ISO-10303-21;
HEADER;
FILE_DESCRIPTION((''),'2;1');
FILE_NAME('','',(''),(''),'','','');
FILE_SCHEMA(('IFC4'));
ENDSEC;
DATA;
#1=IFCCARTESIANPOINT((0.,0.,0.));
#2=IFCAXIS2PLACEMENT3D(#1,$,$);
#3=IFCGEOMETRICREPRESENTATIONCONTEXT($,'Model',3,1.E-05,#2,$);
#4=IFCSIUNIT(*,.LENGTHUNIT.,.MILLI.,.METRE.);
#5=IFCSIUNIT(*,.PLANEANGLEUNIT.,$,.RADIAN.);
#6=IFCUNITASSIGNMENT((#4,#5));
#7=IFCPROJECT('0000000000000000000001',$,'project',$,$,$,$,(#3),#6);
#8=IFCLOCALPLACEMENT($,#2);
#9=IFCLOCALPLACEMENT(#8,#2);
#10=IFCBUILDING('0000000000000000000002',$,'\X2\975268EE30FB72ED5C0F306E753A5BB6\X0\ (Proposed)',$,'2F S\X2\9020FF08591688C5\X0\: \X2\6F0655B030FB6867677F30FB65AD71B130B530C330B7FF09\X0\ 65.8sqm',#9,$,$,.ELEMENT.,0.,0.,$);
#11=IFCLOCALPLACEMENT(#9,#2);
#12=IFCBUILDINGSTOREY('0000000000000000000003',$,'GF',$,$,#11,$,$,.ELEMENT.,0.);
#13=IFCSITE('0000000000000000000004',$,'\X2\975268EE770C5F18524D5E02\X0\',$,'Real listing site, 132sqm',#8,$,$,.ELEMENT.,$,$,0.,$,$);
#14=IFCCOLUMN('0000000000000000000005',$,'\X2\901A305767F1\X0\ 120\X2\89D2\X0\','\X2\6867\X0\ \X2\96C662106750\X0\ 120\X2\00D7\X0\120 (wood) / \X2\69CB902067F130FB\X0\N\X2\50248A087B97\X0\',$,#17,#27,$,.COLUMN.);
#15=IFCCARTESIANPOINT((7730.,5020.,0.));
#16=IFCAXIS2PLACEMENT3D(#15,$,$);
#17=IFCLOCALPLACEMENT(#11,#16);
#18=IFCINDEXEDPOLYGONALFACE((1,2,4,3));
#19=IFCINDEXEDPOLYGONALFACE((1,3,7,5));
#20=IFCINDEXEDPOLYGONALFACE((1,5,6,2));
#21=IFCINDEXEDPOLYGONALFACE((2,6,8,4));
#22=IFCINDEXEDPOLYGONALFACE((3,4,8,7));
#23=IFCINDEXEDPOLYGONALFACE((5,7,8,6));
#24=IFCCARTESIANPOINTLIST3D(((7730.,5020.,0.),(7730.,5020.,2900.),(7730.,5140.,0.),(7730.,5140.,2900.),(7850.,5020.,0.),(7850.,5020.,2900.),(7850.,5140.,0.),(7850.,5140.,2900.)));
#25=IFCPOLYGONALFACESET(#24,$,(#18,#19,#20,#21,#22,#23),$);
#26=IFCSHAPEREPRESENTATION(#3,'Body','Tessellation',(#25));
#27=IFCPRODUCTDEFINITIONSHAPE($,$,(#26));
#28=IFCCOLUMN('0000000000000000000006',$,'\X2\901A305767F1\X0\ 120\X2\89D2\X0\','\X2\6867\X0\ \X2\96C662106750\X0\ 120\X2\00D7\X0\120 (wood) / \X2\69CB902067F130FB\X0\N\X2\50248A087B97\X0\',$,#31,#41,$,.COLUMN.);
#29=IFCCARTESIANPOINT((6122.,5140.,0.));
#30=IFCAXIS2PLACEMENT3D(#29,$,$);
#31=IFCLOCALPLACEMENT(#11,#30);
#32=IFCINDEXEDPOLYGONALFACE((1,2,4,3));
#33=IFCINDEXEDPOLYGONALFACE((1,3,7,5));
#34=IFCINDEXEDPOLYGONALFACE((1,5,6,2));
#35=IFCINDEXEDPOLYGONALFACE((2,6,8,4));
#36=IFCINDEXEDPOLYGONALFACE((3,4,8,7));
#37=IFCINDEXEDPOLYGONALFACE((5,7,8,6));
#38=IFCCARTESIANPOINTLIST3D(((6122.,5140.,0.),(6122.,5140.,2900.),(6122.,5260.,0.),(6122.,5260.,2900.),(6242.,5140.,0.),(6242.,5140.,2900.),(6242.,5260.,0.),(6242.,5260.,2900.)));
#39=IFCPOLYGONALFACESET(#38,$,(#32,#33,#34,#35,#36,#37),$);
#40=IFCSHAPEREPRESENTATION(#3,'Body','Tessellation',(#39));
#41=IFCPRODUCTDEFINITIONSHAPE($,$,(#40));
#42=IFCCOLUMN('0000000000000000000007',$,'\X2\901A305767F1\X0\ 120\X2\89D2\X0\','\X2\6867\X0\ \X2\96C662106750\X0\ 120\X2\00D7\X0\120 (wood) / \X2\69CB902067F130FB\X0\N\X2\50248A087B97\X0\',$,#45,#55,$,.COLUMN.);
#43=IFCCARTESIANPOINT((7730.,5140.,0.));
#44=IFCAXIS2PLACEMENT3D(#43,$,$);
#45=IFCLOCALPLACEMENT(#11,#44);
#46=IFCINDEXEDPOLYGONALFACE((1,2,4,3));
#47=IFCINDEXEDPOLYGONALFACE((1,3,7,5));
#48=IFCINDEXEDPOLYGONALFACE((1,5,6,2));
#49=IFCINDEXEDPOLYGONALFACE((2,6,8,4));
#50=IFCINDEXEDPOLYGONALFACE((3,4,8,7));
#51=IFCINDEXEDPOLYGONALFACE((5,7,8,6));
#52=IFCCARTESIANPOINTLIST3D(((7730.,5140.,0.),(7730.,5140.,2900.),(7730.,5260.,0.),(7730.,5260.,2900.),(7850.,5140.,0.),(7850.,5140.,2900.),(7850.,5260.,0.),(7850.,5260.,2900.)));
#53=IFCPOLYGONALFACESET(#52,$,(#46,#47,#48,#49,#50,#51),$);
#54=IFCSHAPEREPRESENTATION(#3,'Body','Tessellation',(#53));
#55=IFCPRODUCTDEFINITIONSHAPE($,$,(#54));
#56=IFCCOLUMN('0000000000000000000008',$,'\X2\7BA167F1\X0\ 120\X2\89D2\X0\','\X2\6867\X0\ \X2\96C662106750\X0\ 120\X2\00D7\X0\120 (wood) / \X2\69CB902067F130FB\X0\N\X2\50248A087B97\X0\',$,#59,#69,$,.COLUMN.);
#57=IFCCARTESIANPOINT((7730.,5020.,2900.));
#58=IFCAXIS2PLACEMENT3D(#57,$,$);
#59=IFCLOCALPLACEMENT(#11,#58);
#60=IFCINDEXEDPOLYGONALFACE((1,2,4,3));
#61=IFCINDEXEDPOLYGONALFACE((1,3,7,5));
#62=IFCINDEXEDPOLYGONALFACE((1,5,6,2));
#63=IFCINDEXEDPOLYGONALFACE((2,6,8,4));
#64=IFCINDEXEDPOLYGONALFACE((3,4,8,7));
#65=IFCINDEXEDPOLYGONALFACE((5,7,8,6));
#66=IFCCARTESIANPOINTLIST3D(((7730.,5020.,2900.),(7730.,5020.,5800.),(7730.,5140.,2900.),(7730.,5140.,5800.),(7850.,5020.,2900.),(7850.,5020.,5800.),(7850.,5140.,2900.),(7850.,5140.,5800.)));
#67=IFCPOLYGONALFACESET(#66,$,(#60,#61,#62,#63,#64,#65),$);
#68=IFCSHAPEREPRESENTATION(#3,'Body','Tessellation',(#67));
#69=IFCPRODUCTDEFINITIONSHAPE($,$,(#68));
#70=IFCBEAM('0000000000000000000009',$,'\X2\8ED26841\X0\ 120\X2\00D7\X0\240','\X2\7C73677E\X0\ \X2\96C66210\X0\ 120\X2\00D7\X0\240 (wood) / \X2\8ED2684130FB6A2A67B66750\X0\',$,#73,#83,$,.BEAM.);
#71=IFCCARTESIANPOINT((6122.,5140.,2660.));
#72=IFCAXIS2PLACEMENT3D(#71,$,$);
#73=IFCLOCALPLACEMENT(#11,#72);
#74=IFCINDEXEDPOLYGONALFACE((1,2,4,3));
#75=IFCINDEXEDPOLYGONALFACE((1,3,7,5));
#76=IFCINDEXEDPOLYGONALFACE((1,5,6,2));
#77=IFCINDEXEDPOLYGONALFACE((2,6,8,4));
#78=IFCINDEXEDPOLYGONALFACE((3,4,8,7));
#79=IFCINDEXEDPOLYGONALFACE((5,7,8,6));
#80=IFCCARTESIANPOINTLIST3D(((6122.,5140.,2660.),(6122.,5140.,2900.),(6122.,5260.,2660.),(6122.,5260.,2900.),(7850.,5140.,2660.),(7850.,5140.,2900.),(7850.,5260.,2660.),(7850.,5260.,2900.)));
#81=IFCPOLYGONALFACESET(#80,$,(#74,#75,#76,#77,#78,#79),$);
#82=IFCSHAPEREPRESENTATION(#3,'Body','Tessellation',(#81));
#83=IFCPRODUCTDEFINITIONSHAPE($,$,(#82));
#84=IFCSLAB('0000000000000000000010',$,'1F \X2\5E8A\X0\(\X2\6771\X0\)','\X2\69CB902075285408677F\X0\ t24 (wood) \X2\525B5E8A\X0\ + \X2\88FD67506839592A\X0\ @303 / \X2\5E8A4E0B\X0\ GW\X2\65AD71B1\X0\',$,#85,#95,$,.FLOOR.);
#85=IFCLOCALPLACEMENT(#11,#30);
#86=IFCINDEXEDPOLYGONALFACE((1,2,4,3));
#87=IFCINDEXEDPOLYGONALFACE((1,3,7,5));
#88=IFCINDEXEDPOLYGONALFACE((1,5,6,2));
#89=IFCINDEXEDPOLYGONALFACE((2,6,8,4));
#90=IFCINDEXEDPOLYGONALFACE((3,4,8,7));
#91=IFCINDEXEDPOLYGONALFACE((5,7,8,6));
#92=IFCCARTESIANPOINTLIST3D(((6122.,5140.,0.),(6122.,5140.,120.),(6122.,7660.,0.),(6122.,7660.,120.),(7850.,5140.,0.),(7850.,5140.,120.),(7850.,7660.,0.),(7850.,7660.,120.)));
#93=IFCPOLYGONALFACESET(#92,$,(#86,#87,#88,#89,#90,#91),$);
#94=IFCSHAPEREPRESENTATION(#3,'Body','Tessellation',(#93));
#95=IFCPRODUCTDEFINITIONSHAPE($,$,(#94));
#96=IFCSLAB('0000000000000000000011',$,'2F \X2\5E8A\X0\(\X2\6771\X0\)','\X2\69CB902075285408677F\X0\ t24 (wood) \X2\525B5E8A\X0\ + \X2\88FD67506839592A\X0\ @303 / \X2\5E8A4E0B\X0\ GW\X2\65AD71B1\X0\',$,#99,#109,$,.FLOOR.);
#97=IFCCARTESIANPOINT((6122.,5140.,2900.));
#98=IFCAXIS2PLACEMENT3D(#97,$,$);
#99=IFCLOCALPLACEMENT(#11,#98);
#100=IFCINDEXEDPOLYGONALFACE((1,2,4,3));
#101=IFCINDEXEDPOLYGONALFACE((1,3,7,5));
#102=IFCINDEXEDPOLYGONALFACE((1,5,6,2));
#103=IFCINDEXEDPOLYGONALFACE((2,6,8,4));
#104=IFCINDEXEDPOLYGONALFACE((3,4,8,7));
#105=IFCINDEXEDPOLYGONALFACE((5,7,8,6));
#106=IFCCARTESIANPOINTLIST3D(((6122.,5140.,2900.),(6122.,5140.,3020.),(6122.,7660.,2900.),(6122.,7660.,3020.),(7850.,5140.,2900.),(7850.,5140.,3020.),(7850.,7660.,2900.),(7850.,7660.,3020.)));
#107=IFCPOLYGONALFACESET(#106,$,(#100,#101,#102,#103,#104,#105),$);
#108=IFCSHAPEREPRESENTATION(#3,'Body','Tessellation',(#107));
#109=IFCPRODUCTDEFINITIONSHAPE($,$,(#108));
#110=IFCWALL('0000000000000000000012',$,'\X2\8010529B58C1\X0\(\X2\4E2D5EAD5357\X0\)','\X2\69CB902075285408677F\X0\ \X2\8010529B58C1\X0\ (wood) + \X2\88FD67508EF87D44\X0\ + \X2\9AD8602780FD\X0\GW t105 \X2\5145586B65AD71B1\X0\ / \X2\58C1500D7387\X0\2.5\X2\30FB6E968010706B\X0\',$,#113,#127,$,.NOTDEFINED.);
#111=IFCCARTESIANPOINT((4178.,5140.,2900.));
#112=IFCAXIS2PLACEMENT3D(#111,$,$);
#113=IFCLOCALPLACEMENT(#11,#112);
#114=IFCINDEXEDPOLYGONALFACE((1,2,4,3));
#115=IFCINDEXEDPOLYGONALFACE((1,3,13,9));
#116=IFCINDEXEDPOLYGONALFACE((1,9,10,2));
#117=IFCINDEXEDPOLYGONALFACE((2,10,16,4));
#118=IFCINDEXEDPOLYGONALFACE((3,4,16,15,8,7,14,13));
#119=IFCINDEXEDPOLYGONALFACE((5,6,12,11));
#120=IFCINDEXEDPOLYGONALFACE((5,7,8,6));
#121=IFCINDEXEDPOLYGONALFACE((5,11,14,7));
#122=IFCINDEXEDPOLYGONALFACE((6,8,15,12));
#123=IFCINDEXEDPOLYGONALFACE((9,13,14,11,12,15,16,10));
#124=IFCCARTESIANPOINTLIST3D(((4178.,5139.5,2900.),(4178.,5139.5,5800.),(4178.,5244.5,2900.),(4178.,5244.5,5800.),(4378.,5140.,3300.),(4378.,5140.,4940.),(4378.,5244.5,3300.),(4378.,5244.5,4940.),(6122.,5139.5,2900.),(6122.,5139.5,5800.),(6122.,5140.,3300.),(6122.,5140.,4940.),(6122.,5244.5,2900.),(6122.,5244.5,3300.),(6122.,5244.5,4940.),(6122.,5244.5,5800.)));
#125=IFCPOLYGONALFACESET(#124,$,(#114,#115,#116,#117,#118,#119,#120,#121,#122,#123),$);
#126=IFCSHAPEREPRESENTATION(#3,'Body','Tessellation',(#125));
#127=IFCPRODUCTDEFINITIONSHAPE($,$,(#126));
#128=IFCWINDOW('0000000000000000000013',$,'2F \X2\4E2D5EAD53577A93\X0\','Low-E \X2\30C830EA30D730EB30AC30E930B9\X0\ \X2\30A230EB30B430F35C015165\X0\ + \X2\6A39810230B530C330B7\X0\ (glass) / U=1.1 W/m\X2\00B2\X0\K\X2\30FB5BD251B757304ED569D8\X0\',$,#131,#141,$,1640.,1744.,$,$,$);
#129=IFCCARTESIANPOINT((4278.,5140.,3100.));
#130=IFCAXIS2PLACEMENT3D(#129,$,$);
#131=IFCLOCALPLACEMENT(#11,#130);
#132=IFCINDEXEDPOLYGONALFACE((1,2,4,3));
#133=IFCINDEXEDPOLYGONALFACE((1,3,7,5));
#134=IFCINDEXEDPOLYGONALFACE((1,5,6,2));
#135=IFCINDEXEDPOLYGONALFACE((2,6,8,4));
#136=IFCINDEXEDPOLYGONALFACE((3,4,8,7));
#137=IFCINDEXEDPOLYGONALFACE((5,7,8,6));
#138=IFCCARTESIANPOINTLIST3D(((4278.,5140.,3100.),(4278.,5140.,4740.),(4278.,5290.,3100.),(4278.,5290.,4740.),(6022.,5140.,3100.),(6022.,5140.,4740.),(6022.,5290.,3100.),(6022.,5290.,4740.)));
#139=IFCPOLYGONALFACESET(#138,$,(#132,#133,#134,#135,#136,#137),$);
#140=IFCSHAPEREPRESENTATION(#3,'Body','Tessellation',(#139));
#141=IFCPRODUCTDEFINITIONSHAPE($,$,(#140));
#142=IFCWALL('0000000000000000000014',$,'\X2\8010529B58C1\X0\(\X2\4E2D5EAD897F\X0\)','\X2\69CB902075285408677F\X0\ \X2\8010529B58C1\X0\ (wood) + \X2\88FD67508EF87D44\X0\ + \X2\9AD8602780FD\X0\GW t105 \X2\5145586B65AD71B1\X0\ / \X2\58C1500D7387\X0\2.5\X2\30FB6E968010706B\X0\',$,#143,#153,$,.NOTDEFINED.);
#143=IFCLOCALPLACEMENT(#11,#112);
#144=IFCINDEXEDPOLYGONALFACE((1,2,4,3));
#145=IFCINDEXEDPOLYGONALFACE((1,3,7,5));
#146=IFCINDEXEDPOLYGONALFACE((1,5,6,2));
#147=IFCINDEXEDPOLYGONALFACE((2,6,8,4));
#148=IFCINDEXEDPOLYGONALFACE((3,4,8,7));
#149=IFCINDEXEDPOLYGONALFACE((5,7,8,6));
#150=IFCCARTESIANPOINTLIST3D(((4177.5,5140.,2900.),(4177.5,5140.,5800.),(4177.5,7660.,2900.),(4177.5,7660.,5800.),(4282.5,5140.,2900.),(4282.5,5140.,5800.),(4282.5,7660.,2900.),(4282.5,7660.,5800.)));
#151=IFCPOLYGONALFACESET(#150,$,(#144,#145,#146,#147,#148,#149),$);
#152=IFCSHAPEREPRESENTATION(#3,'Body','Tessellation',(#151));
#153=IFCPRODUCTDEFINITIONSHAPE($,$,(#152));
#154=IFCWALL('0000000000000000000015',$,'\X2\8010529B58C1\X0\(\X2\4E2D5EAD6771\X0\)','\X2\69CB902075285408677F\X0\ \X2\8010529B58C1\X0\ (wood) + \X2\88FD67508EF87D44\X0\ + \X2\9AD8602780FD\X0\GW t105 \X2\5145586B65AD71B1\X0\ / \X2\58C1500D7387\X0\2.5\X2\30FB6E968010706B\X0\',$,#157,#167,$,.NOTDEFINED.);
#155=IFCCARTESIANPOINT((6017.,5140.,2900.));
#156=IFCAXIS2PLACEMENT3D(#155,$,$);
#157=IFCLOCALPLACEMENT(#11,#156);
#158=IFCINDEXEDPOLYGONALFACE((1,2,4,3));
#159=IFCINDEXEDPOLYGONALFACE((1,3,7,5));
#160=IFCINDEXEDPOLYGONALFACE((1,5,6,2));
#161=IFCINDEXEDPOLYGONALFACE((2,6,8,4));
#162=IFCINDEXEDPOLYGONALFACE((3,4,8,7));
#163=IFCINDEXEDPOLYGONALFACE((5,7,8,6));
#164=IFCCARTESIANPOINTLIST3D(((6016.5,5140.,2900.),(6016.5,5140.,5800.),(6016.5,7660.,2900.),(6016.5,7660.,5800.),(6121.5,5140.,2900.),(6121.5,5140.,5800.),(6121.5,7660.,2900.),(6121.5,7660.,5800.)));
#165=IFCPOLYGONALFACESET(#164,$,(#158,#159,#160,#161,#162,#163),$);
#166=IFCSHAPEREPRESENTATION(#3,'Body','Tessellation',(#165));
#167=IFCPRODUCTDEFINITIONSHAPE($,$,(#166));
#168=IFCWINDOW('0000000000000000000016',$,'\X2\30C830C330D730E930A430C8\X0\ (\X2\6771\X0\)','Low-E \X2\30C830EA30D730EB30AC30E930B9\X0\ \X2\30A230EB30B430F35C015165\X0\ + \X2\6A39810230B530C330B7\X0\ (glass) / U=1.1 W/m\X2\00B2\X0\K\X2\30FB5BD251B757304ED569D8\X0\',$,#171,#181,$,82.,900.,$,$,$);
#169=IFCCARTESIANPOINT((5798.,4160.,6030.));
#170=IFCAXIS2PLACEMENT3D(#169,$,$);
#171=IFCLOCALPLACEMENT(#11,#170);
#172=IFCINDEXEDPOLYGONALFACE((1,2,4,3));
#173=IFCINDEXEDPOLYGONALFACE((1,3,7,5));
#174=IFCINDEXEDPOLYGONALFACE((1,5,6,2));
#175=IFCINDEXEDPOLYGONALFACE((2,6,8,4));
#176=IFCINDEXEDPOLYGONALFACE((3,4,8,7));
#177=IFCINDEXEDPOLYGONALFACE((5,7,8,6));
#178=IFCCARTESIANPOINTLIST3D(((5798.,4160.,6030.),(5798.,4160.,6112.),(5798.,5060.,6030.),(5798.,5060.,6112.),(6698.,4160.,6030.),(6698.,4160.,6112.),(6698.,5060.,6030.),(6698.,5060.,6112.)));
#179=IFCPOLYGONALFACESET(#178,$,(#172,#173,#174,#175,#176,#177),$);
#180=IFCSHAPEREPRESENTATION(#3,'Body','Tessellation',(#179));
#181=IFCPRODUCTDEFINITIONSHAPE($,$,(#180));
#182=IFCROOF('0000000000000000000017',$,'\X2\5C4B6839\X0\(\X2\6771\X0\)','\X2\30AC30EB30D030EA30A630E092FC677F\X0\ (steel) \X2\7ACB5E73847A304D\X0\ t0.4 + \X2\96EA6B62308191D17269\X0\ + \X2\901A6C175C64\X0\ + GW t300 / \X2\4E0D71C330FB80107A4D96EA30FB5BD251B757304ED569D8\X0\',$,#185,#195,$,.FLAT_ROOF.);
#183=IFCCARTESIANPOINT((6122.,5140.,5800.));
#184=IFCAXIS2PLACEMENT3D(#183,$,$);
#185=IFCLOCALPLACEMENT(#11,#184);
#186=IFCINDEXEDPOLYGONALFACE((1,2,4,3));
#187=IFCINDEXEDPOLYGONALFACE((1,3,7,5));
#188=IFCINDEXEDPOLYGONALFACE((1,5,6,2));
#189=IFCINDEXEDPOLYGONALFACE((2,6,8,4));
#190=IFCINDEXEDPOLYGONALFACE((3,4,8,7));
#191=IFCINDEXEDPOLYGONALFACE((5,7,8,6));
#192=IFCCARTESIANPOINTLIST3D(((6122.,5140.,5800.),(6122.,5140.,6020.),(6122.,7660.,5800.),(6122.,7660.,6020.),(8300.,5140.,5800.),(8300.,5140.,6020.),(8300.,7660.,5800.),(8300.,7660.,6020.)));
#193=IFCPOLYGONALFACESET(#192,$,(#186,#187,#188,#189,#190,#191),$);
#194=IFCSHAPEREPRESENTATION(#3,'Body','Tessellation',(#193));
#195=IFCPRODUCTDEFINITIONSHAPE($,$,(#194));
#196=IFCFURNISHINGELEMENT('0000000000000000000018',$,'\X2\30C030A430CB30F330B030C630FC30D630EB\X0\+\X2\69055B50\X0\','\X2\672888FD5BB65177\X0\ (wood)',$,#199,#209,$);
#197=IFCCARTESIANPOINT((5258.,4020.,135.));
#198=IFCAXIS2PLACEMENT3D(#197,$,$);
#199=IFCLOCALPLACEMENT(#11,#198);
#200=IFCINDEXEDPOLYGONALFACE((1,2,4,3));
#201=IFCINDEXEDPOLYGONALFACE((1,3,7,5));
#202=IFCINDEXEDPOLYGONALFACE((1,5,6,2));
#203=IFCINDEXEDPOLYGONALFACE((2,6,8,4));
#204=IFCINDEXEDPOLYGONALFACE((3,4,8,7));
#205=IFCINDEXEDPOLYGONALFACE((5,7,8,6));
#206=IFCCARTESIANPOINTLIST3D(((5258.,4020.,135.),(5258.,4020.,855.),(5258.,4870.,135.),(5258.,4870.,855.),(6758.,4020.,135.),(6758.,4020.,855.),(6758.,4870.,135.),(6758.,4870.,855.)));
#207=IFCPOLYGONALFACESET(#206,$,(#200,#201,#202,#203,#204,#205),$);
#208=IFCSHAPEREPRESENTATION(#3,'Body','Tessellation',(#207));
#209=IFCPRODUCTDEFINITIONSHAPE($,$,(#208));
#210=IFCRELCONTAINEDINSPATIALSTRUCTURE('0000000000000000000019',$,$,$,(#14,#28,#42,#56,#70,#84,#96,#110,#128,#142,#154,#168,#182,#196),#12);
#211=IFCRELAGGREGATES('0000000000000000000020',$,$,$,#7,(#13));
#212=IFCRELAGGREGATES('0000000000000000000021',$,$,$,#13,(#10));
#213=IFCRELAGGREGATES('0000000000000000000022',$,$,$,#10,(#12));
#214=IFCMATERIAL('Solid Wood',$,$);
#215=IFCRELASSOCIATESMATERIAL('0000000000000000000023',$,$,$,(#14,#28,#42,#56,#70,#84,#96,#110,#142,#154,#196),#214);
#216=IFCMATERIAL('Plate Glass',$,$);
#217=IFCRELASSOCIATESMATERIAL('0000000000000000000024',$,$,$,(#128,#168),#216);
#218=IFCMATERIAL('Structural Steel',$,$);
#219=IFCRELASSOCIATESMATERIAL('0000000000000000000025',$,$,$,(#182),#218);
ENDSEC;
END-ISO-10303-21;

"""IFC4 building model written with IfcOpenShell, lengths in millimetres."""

from ifc_helpers import new_model, si_unit, frame, frame_2d, origin, place, context, project, spatial, rectangle, extrude, material, element, fill, save


model = new_model("IFC4")

# Units and contexts
model_context = context("Model", 3, precision=1e-05, world=origin())
ifc_project = project(units=[si_unit("LENGTHUNIT", "METRE", prefix="MILLI"), si_unit("PLANEANGLEUNIT", "RADIAN")], contexts=[model_context])

# Site, building, storey
site_placement = place(None, origin())
site = spatial("IfcSite", under=ifc_project, at=site_placement, Name="青森県弘前市", ObjectType="Real listing site, 132sqm", CompositionType="ELEMENT", RefElevation=0.0)
building_placement = place(site_placement, origin())
building = spatial("IfcBuilding", under=site, at=building_placement, Name="青森・狭小の町家 (Proposed)", ObjectType="2F S造（外装: 漆喰・桧板・断熱サッシ） 65.8sqm", CompositionType="ELEMENT", ElevationOfRefHeight=0.0, ElevationOfTerrain=0.0)
storey_placement = place(building_placement, origin())
storey = spatial("IfcBuildingStorey", under=building, at=storey_placement, Name="GF", CompositionType="ELEMENT", Elevation=0.0)

# Columns
ifc_material_1 = material(Name="Solid Wood")
column_1_placement = place(storey_placement, frame((7730.0, 5020.0, 0.0)))
element("IfcColumn", 1, at=column_1_placement, inside=storey, material=ifc_material_1, Name="通し柱 120角", Description="桧 集成材 120×120 (wood) / 構造柱・N値計算", PredefinedType="COLUMN", context=model_context, shape_type="SweptSolid", body=[
    extrude(rectangle(XDim=120.0, YDim=120.0, at=frame_2d((60.0, 60.0))), frame((7730.0, 5020.0, 0.0)), (0.0, 0.0, 1.0), 2900.0),
])
column_2_placement = place(storey_placement, frame((6122.0, 5140.0, 0.0)))
element("IfcColumn", 2, at=column_2_placement, inside=storey, material=ifc_material_1, Name="通し柱 120角", Description="桧 集成材 120×120 (wood) / 構造柱・N値計算", PredefinedType="COLUMN", context=model_context, shape_type="SweptSolid", body=[
    extrude(rectangle(XDim=120.0, YDim=120.0, at=frame_2d((60.0, 60.0))), frame((6122.0, 5140.0, 0.0)), (0.0, 0.0, 1.0), 2900.0),
])
column_3_placement = place(storey_placement, frame((7730.0, 5140.0, 0.0)))
element("IfcColumn", 3, at=column_3_placement, inside=storey, material=ifc_material_1, Name="通し柱 120角", Description="桧 集成材 120×120 (wood) / 構造柱・N値計算", PredefinedType="COLUMN", context=model_context, shape_type="SweptSolid", body=[
    extrude(rectangle(XDim=120.0, YDim=120.0, at=frame_2d((60.0, 60.0))), frame((7730.0, 5140.0, 0.0)), (0.0, 0.0, 1.0), 2900.0),
])
column_4_placement = place(storey_placement, frame((7730.0, 5020.0, 2900.0)))
element("IfcColumn", 4, at=column_4_placement, inside=storey, material=ifc_material_1, Name="管柱 120角", Description="桧 集成材 120×120 (wood) / 構造柱・N値計算", PredefinedType="COLUMN", context=model_context, shape_type="SweptSolid", body=[
    extrude(rectangle(XDim=120.0, YDim=120.0, at=frame_2d((60.0, 60.0))), frame((7730.0, 5020.0, 2900.0)), (0.0, 0.0, 1.0), 2900.0),
])

# Beam
beam_1_placement = place(storey_placement, frame((6122.0, 5140.0, 2660.0)))
element("IfcBeam", 5, at=beam_1_placement, inside=storey, material=ifc_material_1, Name="軒桁 120×240", Description="米松 集成 120×240 (wood) / 軒桁・横架材", PredefinedType="BEAM", context=model_context, shape_type="SweptSolid", body=[
    extrude(rectangle(XDim=1728.0, YDim=120.0, at=frame_2d((864.0, 60.0))), frame((6122.0, 5140.0, 2660.0)), (0.0, 0.0, 1.0), 240.0),
])

# Slabs
slab_1_placement = place(storey_placement, frame((6122.0, 5140.0, 0.0)))
element("IfcSlab", 6, at=slab_1_placement, inside=storey, material=ifc_material_1, Name="1F 床(東)", Description="構造用合板 t24 (wood) 剛床 + 製材根太 @303 / 床下 GW断熱", PredefinedType="FLOOR", context=model_context, shape_type="SweptSolid", body=[
    extrude(rectangle(XDim=1728.0, YDim=2520.0, at=frame_2d((864.0, 1260.0))), frame((6122.0, 5140.0, 0.0)), (0.0, 0.0, 1.0), 120.0),
])
slab_2_placement = place(storey_placement, frame((6122.0, 5140.0, 2900.0)))
element("IfcSlab", 7, at=slab_2_placement, inside=storey, material=ifc_material_1, Name="2F 床(東)", Description="構造用合板 t24 (wood) 剛床 + 製材根太 @303 / 床下 GW断熱", PredefinedType="FLOOR", context=model_context, shape_type="SweptSolid", body=[
    extrude(rectangle(XDim=1728.0, YDim=2520.0, at=frame_2d((864.0, 1260.0))), frame((6122.0, 5140.0, 2900.0)), (0.0, 0.0, 1.0), 120.0),
])

# Wall, opening, window
wall_1_placement = place(storey_placement, frame((4178.0, 5140.0, 2900.0)))
wall_1 = element("IfcWall", 8, at=wall_1_placement, inside=storey, material=ifc_material_1, Name="耐力壁(中庭南)", Description="構造用合板 耐力壁 (wood) + 製材軸組 + 高性能GW t105 充填断熱 / 壁倍率2.5・準耐火", PredefinedType="NOTDEFINED", context=model_context, shape_type="SweptSolid", body=[
    extrude(rectangle(XDim=1944.0, YDim=105.0, at=frame_2d((972.0, 52.0))), frame((4178.0, 5140.0, 2900.0)), (0.0, 0.0, 1.0), 2900.0),
])
opening_placement = place(storey_placement, frame((4278.0, 5140.0, 3100.0)))
opening = element("IfcOpeningElement", 9, at=opening_placement, cuts=wall_1, PredefinedType="NOTDEFINED", context=model_context, shape_type="SweptSolid", body=[
    extrude(rectangle(XDim=1744.0, YDim=150.0, at=frame_2d((872.0, 75.0))), frame((4278.0, 5140.0, 3100.0)), (0.0, 0.0, 1.0), 1640.0),
])
ifc_material_2 = material(Name="Plate Glass")
window_1_placement = place(storey_placement, frame((4278.0, 5140.0, 3100.0)))
window_1 = element("IfcWindow", 10, at=window_1_placement, inside=storey, material=ifc_material_2, Name="2F 中庭南窓", Description="Low-E トリプルガラス アルゴン封入 + 樹脂サッシ (glass) / U=1.1 W/m²K・寒冷地仕様", OverallHeight=1640.0, OverallWidth=1744.0, context=model_context, shape_type="SweptSolid", body=[
    extrude(rectangle(XDim=1744.0, YDim=150.0, at=frame_2d((872.0, 75.0))), frame((4278.0, 5140.0, 3100.0)), (0.0, 0.0, 1.0), 1640.0),
])
fill(opening, window_1)

# Walls
wall_2_placement = place(storey_placement, frame((4178.0, 5140.0, 2900.0)))
element("IfcWall", 11, at=wall_2_placement, inside=storey, material=ifc_material_1, Name="耐力壁(中庭西)", Description="構造用合板 耐力壁 (wood) + 製材軸組 + 高性能GW t105 充填断熱 / 壁倍率2.5・準耐火", PredefinedType="NOTDEFINED", context=model_context, shape_type="SweptSolid", body=[
    extrude(rectangle(XDim=105.0, YDim=2520.0, at=frame_2d((52.0, 1260.0))), frame((4178.0, 5140.0, 2900.0)), (0.0, 0.0, 1.0), 2900.0),
])
wall_3_placement = place(storey_placement, frame((6017.0, 5140.0, 2900.0)))
element("IfcWall", 12, at=wall_3_placement, inside=storey, material=ifc_material_1, Name="耐力壁(中庭東)", Description="構造用合板 耐力壁 (wood) + 製材軸組 + 高性能GW t105 充填断熱 / 壁倍率2.5・準耐火", PredefinedType="NOTDEFINED", context=model_context, shape_type="SweptSolid", body=[
    extrude(rectangle(XDim=105.0, YDim=2520.0, at=frame_2d((52.0, 1260.0))), frame((6017.0, 5140.0, 2900.0)), (0.0, 0.0, 1.0), 2900.0),
])

# Window
window_2_placement = place(storey_placement, frame((5798.0, 4160.0, 6030.0)))
element("IfcWindow", 13, at=window_2_placement, inside=storey, material=ifc_material_2, Name="トップライト (東)", Description="Low-E トリプルガラス アルゴン封入 + 樹脂サッシ (glass) / U=1.1 W/m²K・寒冷地仕様", OverallHeight=82.0, OverallWidth=900.0, context=model_context, shape_type="SweptSolid", body=[
    extrude(rectangle(XDim=900.0, YDim=900.0, at=frame_2d((450.0, 450.0))), frame((5798.0, 4160.0, 6030.0)), (0.0, 0.0, 1.0), 82.0),
])

# Roof
ifc_material_3 = material(Name="Structural Steel")
for number, where, name in (
    (14, (6122.0, 5140.0, 5800.0), "屋根(東)"),
):
    element("IfcRoof", number, at=place(storey_placement, frame(where)), inside=storey, material=ifc_material_3, Name=name, Description="ガルバリウム鋼板 (steel) 立平葺き t0.4 + 雪止め金物 + 通気層 + GW t300 / 不燃・耐積雪・寒冷地仕様", PredefinedType="FLAT_ROOF", context=model_context, shape_type="SweptSolid", body=[
        extrude(rectangle(XDim=2178.0, YDim=2520.0, at=frame_2d((1089.0, 1260.0))), frame((6122.0, 5140.0, 5800.0)), (0.0, 0.0, 1.0), 220.0),
    ])

# Furnishing element
furnishing_1_placement = place(storey_placement, frame((5258.0, 4020.0, 135.0)))
element("IfcFurnishingElement", 15, at=furnishing_1_placement, inside=storey, material=ifc_material_1, Name="ダイニングテーブル+椅子", Description="木製家具 (wood)", context=model_context, shape_type="SweptSolid", body=[
    extrude(rectangle(XDim=1500.0, YDim=850.0, at=frame_2d((750.0, 425.0))), frame((5258.0, 4020.0, 135.0)), (0.0, 0.0, 1.0), 720.0),
])

save(model, "model.ifc")
